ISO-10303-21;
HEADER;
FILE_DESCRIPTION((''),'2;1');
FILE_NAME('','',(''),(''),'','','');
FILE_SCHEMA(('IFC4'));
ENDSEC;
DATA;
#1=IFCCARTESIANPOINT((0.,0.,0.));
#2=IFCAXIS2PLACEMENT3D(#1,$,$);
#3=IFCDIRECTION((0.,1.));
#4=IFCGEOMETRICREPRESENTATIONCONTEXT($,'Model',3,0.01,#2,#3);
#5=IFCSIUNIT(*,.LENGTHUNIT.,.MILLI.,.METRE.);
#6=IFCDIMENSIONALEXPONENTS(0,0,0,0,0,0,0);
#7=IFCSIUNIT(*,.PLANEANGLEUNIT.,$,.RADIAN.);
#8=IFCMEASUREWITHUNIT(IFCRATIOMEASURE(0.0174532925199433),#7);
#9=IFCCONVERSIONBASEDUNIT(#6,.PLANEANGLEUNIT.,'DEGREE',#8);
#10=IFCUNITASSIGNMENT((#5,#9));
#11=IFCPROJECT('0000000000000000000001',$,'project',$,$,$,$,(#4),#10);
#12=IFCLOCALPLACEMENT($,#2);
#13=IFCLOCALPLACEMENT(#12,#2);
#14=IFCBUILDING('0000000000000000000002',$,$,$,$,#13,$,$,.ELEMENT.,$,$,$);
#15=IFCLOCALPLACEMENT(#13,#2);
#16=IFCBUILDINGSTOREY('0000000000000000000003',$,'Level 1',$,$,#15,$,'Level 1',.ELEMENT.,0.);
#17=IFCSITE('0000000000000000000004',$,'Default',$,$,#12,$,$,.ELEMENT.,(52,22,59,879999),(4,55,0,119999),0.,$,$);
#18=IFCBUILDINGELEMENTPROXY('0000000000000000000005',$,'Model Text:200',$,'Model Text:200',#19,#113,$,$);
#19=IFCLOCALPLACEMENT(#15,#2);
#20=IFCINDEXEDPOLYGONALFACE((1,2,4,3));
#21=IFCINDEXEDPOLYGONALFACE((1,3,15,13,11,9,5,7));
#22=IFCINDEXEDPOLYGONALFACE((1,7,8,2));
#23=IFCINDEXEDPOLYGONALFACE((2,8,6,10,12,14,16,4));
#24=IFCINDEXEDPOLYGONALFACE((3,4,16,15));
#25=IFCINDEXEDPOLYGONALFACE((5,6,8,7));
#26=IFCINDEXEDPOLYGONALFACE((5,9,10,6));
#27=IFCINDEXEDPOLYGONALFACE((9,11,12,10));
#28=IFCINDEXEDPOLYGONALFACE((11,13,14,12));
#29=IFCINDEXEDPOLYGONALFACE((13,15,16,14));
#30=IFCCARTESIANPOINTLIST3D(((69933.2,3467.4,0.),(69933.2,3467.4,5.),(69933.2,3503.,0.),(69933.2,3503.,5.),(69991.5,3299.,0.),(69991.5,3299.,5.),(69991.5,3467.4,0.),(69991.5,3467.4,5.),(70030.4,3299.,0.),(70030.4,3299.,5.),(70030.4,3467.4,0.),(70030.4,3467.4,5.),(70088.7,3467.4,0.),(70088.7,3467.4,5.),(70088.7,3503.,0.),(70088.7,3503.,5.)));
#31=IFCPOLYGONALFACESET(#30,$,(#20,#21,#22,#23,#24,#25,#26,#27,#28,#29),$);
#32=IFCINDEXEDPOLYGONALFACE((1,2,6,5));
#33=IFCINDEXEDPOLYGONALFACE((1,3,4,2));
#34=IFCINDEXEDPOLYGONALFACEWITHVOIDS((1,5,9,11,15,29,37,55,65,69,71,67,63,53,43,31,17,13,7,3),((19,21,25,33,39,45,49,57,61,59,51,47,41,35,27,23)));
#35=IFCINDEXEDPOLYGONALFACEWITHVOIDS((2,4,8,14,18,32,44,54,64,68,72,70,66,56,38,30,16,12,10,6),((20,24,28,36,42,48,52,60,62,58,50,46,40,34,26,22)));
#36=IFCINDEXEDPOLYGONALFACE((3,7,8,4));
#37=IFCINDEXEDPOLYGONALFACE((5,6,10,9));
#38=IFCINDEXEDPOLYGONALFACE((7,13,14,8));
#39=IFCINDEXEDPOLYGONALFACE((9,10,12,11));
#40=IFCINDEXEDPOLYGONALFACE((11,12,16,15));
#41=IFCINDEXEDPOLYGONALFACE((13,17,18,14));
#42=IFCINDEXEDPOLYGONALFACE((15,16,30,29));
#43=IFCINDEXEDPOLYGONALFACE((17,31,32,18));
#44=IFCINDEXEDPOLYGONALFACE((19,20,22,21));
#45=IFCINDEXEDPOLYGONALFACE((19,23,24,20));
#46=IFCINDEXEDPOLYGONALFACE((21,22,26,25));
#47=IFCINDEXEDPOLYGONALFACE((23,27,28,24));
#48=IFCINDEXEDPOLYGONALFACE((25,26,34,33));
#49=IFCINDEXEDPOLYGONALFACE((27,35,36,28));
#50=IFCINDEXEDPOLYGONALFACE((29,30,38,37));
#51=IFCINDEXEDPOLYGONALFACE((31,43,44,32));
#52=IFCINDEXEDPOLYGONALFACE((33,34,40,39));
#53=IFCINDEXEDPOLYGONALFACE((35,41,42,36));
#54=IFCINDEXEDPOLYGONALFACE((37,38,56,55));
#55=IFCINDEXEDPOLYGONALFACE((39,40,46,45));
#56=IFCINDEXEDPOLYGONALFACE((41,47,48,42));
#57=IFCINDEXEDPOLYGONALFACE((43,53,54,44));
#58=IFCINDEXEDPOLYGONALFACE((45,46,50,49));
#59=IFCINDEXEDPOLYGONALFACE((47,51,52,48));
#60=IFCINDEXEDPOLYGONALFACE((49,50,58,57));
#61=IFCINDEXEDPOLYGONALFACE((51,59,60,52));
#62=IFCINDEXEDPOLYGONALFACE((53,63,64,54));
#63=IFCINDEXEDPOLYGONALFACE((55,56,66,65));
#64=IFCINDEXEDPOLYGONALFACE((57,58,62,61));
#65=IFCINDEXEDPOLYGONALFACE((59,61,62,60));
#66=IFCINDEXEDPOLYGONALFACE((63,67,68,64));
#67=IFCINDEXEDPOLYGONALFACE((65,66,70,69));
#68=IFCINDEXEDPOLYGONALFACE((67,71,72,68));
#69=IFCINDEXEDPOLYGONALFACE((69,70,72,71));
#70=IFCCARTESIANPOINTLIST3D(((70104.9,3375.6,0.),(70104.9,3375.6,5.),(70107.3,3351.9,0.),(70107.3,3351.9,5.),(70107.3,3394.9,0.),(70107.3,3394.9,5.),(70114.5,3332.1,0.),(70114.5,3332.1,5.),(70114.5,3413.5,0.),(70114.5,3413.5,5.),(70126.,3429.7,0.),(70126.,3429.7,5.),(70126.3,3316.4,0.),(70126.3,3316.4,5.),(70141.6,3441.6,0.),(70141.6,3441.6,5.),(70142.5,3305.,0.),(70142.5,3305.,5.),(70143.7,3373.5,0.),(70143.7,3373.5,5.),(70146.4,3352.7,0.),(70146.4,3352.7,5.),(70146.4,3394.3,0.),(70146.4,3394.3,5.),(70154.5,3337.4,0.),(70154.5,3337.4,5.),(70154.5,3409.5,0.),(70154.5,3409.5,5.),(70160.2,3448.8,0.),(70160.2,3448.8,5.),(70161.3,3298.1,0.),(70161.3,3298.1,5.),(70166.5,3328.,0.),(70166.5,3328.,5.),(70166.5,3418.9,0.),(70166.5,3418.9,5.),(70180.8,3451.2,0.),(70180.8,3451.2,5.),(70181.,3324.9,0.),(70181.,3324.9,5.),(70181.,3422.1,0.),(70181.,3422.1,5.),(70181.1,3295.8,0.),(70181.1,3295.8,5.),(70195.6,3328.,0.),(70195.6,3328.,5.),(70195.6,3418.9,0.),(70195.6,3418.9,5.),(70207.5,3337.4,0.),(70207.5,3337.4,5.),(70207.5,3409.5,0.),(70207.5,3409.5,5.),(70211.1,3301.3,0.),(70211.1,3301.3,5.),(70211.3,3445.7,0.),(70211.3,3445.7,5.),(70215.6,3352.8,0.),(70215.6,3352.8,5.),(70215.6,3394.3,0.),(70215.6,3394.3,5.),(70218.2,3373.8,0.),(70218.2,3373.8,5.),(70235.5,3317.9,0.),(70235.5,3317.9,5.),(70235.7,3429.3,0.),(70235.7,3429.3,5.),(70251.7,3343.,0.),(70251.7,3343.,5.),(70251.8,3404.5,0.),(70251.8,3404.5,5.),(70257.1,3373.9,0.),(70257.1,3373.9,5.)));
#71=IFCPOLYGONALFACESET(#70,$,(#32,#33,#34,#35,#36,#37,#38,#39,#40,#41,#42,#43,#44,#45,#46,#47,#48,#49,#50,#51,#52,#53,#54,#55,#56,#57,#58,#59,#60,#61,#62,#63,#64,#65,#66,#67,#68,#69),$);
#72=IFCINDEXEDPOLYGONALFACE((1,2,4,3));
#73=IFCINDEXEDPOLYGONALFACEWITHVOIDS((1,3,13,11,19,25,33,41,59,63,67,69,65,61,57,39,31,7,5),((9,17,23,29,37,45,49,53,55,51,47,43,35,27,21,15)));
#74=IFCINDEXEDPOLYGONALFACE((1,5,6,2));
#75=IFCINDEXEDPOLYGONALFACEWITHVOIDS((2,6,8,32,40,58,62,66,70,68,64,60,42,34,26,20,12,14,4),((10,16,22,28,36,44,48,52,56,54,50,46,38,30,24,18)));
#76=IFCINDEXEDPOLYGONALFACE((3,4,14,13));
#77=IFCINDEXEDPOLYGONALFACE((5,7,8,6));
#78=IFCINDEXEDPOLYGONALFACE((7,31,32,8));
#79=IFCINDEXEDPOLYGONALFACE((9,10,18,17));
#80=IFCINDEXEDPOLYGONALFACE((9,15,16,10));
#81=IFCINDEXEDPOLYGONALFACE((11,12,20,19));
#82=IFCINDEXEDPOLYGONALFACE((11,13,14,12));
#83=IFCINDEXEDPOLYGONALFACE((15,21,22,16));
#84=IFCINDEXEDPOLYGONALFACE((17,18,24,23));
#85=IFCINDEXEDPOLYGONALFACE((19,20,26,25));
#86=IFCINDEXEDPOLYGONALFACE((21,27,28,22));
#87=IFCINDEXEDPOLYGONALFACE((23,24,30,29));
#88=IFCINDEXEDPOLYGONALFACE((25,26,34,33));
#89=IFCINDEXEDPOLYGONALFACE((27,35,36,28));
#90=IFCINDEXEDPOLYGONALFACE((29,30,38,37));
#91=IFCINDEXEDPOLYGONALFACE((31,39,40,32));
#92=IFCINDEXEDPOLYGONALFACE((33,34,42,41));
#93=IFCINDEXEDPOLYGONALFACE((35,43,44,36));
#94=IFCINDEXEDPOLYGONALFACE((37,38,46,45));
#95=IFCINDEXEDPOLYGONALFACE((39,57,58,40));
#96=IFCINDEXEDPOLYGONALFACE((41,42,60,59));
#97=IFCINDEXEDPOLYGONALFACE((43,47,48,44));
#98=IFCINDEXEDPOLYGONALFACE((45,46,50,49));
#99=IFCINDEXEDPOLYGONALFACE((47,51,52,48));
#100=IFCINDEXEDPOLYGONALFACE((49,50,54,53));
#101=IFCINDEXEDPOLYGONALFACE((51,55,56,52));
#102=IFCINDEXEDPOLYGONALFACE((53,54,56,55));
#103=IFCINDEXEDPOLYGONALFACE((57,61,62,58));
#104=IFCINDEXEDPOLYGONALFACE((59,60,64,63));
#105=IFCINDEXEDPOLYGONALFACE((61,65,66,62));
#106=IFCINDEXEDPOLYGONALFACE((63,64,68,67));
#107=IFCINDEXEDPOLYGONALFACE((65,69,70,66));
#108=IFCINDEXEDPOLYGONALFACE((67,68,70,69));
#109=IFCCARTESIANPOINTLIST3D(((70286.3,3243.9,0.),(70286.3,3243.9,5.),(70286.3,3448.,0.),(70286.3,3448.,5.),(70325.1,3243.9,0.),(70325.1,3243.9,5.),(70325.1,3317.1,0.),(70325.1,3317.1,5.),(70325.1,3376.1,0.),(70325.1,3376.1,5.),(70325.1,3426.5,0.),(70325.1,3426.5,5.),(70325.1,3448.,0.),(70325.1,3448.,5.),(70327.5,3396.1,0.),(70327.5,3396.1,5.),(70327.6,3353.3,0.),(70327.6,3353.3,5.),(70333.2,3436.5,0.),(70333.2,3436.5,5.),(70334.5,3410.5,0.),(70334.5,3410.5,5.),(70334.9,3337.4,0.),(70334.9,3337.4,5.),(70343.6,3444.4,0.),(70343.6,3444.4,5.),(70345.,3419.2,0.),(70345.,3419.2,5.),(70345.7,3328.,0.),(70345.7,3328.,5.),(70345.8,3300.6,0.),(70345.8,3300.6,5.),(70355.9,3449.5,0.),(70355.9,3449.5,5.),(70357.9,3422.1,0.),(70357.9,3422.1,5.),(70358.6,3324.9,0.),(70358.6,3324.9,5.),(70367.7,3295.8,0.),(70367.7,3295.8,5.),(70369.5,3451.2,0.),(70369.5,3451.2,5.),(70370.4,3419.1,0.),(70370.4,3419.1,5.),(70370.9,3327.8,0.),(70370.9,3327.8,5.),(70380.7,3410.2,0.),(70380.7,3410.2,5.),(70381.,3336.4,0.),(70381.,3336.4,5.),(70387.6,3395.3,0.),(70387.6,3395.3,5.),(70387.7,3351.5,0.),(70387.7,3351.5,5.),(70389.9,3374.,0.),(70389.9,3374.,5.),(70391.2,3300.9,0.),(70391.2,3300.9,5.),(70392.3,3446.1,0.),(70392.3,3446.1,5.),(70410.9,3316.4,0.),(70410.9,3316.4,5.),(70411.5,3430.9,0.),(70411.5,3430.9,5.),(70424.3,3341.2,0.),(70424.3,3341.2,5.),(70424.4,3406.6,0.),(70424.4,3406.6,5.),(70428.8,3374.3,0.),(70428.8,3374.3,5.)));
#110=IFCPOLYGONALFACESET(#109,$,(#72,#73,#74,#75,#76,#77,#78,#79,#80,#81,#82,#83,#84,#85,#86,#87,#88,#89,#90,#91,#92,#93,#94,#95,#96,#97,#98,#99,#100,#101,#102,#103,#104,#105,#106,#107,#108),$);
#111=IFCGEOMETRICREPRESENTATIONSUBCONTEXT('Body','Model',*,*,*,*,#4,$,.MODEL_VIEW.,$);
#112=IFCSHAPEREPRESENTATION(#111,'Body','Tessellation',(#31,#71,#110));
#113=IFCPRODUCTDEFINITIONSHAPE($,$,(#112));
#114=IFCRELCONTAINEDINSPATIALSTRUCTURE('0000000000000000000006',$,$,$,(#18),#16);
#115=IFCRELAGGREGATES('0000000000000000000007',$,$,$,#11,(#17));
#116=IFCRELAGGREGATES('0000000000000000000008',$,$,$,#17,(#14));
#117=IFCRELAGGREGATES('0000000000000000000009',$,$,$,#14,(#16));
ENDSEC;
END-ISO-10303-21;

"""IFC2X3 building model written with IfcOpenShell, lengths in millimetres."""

from ifc_helpers import new_model, entity, si_unit, converted_unit, direction, frame, origin, place, context, subcontext, project, spatial, polyline, outline, extrude, element, save


model = new_model("IFC2X3")

# Units and contexts
model_context = context("Model", 3, precision=0.01, world=origin(), true_north=direction((0.0, 1.0)))
body_context = subcontext(model_context, "Body", "Model", "MODEL_VIEW")
ifc_project = project(units=[si_unit("LENGTHUNIT", "METRE", prefix="MILLI"), converted_unit("PLANEANGLEUNIT", "DEGREE", entity("IfcRatioMeasure", 0.0174532925199433), si_unit("PLANEANGLEUNIT", "RADIAN"), dimensions=[0, 0, 0, 0, 0, 0, 0])], contexts=[model_context])

# Site, building, storey
site_placement = place(None, origin())
site = spatial("IfcSite", under=ifc_project, at=site_placement, Name="Default", CompositionType="ELEMENT", RefLatitude=(52, 22, 59, 879999), RefLongitude=(4, 55, 0, 119999), RefElevation=0.0)
building_placement = place(site_placement, origin())
building = spatial("IfcBuilding", under=site, at=building_placement, CompositionType="ELEMENT")
storey_placement = place(building_placement, origin())
storey = spatial("IfcBuildingStorey", under=building, at=storey_placement, Name="Level 1", LongName="Level 1", CompositionType="ELEMENT", Elevation=0.0)

# Building element proxy
proxy_1_placement = place(building_placement, origin())
element("IfcBuildingElementProxy", 1, at=proxy_1_placement, inside=storey, Name="Model Text:200", ObjectType="Model Text:200", context=body_context, shape_type="SweptSolid", body=[
    extrude(outline(polyline([(-19.4, -135.2), (19.4, -135.2), (19.4, 33.2), (77.7, 33.2), (77.7, 68.8), (-77.7, 68.8), (-77.7, 33.2), (-19.4, 33.2), (-19.4, -135.2)])), frame((70010.9, 3434.2, 0.0)), (0.0, 0.0, 1.0), 5.0),
    extrude(outline(polyline([(-8.8, -65.7), (15.1, -65.7), (35.5, -60.5), (52.3, -50.4), (65.3, -35.4), (74.1, -17.3), (78.4, 2.1), (75.9, 32.5), (61.8, 58.5), (38.4, 77.1), (8.3, 85.6), (-22.7, 83.3), (-49.0, 69.9), (-67.8, 47.3), (-76.3, 17.5), (-76.0, -3.3), (-70.7, -22.5), (-60.5, -39.2), (-45.5, -52.3), (-27.7, -61.4), (-8.8, -65.7)]), holes=[polyline([(-2.7, -27.2), (-23.1, -22.5), (-37.5, -12.9), (-45.7, 0.0), (-47.3, 14.8), (-42.7, 28.9), (-32.2, 39.9), (-16.3, 46.3), (4.5, 46.9), (25.1, 42.1), (39.6, 32.6), (47.7, 19.7), (49.4, 5.0), (44.8, -9.2), (34.2, -20.2), (18.2, -26.7), (-2.7, -27.2)])]), frame((70171.1, 3373.5, 0.0), z_axis=(0.0, 0.0, 1.0), x_axis=(0.100608, -0.994926, 0.0)), (0.0, 0.0, 1.0), 5.0),
    extrude(outline(polyline([(-73.1, -75.4), (130.9, -75.4), (130.9, -36.6), (57.8, -36.6), (74.3, -15.9), (79.1, 6.0), (73.9, 29.5), (58.4, 49.2), (33.6, 62.6), (0.5, 67.1), (-31.8, 62.8), (-56.1, 49.8), (-71.3, 30.7), (-76.4, 7.8), (-74.7, -5.8), (-69.6, -18.1), (-61.7, -28.5), (-51.7, -36.6), (-73.1, -36.6), (-73.1, -75.4)]), holes=[polyline([(-1.2, -36.6), (-21.2, -34.2), (-35.6, -27.2), (-44.3, -16.7), (-47.2, -3.8), (-44.3, 8.7), (-35.4, 19.0), (-20.4, 25.9), (0.8, 28.2), (23.3, 26.0), (38.5, 19.3), (47.1, 9.2), (49.9, -3.1), (46.8, -16.0), (37.4, -26.8), (21.5, -34.1), (-1.2, -36.6)])]), frame((70361.7, 3374.8, 0.0), z_axis=(0.0, 0.0, 1.0), x_axis=(0.0, -1.0, 0.0)), (0.0, 0.0, 1.0), 5.0),
])

save(model, "model.ifc")
